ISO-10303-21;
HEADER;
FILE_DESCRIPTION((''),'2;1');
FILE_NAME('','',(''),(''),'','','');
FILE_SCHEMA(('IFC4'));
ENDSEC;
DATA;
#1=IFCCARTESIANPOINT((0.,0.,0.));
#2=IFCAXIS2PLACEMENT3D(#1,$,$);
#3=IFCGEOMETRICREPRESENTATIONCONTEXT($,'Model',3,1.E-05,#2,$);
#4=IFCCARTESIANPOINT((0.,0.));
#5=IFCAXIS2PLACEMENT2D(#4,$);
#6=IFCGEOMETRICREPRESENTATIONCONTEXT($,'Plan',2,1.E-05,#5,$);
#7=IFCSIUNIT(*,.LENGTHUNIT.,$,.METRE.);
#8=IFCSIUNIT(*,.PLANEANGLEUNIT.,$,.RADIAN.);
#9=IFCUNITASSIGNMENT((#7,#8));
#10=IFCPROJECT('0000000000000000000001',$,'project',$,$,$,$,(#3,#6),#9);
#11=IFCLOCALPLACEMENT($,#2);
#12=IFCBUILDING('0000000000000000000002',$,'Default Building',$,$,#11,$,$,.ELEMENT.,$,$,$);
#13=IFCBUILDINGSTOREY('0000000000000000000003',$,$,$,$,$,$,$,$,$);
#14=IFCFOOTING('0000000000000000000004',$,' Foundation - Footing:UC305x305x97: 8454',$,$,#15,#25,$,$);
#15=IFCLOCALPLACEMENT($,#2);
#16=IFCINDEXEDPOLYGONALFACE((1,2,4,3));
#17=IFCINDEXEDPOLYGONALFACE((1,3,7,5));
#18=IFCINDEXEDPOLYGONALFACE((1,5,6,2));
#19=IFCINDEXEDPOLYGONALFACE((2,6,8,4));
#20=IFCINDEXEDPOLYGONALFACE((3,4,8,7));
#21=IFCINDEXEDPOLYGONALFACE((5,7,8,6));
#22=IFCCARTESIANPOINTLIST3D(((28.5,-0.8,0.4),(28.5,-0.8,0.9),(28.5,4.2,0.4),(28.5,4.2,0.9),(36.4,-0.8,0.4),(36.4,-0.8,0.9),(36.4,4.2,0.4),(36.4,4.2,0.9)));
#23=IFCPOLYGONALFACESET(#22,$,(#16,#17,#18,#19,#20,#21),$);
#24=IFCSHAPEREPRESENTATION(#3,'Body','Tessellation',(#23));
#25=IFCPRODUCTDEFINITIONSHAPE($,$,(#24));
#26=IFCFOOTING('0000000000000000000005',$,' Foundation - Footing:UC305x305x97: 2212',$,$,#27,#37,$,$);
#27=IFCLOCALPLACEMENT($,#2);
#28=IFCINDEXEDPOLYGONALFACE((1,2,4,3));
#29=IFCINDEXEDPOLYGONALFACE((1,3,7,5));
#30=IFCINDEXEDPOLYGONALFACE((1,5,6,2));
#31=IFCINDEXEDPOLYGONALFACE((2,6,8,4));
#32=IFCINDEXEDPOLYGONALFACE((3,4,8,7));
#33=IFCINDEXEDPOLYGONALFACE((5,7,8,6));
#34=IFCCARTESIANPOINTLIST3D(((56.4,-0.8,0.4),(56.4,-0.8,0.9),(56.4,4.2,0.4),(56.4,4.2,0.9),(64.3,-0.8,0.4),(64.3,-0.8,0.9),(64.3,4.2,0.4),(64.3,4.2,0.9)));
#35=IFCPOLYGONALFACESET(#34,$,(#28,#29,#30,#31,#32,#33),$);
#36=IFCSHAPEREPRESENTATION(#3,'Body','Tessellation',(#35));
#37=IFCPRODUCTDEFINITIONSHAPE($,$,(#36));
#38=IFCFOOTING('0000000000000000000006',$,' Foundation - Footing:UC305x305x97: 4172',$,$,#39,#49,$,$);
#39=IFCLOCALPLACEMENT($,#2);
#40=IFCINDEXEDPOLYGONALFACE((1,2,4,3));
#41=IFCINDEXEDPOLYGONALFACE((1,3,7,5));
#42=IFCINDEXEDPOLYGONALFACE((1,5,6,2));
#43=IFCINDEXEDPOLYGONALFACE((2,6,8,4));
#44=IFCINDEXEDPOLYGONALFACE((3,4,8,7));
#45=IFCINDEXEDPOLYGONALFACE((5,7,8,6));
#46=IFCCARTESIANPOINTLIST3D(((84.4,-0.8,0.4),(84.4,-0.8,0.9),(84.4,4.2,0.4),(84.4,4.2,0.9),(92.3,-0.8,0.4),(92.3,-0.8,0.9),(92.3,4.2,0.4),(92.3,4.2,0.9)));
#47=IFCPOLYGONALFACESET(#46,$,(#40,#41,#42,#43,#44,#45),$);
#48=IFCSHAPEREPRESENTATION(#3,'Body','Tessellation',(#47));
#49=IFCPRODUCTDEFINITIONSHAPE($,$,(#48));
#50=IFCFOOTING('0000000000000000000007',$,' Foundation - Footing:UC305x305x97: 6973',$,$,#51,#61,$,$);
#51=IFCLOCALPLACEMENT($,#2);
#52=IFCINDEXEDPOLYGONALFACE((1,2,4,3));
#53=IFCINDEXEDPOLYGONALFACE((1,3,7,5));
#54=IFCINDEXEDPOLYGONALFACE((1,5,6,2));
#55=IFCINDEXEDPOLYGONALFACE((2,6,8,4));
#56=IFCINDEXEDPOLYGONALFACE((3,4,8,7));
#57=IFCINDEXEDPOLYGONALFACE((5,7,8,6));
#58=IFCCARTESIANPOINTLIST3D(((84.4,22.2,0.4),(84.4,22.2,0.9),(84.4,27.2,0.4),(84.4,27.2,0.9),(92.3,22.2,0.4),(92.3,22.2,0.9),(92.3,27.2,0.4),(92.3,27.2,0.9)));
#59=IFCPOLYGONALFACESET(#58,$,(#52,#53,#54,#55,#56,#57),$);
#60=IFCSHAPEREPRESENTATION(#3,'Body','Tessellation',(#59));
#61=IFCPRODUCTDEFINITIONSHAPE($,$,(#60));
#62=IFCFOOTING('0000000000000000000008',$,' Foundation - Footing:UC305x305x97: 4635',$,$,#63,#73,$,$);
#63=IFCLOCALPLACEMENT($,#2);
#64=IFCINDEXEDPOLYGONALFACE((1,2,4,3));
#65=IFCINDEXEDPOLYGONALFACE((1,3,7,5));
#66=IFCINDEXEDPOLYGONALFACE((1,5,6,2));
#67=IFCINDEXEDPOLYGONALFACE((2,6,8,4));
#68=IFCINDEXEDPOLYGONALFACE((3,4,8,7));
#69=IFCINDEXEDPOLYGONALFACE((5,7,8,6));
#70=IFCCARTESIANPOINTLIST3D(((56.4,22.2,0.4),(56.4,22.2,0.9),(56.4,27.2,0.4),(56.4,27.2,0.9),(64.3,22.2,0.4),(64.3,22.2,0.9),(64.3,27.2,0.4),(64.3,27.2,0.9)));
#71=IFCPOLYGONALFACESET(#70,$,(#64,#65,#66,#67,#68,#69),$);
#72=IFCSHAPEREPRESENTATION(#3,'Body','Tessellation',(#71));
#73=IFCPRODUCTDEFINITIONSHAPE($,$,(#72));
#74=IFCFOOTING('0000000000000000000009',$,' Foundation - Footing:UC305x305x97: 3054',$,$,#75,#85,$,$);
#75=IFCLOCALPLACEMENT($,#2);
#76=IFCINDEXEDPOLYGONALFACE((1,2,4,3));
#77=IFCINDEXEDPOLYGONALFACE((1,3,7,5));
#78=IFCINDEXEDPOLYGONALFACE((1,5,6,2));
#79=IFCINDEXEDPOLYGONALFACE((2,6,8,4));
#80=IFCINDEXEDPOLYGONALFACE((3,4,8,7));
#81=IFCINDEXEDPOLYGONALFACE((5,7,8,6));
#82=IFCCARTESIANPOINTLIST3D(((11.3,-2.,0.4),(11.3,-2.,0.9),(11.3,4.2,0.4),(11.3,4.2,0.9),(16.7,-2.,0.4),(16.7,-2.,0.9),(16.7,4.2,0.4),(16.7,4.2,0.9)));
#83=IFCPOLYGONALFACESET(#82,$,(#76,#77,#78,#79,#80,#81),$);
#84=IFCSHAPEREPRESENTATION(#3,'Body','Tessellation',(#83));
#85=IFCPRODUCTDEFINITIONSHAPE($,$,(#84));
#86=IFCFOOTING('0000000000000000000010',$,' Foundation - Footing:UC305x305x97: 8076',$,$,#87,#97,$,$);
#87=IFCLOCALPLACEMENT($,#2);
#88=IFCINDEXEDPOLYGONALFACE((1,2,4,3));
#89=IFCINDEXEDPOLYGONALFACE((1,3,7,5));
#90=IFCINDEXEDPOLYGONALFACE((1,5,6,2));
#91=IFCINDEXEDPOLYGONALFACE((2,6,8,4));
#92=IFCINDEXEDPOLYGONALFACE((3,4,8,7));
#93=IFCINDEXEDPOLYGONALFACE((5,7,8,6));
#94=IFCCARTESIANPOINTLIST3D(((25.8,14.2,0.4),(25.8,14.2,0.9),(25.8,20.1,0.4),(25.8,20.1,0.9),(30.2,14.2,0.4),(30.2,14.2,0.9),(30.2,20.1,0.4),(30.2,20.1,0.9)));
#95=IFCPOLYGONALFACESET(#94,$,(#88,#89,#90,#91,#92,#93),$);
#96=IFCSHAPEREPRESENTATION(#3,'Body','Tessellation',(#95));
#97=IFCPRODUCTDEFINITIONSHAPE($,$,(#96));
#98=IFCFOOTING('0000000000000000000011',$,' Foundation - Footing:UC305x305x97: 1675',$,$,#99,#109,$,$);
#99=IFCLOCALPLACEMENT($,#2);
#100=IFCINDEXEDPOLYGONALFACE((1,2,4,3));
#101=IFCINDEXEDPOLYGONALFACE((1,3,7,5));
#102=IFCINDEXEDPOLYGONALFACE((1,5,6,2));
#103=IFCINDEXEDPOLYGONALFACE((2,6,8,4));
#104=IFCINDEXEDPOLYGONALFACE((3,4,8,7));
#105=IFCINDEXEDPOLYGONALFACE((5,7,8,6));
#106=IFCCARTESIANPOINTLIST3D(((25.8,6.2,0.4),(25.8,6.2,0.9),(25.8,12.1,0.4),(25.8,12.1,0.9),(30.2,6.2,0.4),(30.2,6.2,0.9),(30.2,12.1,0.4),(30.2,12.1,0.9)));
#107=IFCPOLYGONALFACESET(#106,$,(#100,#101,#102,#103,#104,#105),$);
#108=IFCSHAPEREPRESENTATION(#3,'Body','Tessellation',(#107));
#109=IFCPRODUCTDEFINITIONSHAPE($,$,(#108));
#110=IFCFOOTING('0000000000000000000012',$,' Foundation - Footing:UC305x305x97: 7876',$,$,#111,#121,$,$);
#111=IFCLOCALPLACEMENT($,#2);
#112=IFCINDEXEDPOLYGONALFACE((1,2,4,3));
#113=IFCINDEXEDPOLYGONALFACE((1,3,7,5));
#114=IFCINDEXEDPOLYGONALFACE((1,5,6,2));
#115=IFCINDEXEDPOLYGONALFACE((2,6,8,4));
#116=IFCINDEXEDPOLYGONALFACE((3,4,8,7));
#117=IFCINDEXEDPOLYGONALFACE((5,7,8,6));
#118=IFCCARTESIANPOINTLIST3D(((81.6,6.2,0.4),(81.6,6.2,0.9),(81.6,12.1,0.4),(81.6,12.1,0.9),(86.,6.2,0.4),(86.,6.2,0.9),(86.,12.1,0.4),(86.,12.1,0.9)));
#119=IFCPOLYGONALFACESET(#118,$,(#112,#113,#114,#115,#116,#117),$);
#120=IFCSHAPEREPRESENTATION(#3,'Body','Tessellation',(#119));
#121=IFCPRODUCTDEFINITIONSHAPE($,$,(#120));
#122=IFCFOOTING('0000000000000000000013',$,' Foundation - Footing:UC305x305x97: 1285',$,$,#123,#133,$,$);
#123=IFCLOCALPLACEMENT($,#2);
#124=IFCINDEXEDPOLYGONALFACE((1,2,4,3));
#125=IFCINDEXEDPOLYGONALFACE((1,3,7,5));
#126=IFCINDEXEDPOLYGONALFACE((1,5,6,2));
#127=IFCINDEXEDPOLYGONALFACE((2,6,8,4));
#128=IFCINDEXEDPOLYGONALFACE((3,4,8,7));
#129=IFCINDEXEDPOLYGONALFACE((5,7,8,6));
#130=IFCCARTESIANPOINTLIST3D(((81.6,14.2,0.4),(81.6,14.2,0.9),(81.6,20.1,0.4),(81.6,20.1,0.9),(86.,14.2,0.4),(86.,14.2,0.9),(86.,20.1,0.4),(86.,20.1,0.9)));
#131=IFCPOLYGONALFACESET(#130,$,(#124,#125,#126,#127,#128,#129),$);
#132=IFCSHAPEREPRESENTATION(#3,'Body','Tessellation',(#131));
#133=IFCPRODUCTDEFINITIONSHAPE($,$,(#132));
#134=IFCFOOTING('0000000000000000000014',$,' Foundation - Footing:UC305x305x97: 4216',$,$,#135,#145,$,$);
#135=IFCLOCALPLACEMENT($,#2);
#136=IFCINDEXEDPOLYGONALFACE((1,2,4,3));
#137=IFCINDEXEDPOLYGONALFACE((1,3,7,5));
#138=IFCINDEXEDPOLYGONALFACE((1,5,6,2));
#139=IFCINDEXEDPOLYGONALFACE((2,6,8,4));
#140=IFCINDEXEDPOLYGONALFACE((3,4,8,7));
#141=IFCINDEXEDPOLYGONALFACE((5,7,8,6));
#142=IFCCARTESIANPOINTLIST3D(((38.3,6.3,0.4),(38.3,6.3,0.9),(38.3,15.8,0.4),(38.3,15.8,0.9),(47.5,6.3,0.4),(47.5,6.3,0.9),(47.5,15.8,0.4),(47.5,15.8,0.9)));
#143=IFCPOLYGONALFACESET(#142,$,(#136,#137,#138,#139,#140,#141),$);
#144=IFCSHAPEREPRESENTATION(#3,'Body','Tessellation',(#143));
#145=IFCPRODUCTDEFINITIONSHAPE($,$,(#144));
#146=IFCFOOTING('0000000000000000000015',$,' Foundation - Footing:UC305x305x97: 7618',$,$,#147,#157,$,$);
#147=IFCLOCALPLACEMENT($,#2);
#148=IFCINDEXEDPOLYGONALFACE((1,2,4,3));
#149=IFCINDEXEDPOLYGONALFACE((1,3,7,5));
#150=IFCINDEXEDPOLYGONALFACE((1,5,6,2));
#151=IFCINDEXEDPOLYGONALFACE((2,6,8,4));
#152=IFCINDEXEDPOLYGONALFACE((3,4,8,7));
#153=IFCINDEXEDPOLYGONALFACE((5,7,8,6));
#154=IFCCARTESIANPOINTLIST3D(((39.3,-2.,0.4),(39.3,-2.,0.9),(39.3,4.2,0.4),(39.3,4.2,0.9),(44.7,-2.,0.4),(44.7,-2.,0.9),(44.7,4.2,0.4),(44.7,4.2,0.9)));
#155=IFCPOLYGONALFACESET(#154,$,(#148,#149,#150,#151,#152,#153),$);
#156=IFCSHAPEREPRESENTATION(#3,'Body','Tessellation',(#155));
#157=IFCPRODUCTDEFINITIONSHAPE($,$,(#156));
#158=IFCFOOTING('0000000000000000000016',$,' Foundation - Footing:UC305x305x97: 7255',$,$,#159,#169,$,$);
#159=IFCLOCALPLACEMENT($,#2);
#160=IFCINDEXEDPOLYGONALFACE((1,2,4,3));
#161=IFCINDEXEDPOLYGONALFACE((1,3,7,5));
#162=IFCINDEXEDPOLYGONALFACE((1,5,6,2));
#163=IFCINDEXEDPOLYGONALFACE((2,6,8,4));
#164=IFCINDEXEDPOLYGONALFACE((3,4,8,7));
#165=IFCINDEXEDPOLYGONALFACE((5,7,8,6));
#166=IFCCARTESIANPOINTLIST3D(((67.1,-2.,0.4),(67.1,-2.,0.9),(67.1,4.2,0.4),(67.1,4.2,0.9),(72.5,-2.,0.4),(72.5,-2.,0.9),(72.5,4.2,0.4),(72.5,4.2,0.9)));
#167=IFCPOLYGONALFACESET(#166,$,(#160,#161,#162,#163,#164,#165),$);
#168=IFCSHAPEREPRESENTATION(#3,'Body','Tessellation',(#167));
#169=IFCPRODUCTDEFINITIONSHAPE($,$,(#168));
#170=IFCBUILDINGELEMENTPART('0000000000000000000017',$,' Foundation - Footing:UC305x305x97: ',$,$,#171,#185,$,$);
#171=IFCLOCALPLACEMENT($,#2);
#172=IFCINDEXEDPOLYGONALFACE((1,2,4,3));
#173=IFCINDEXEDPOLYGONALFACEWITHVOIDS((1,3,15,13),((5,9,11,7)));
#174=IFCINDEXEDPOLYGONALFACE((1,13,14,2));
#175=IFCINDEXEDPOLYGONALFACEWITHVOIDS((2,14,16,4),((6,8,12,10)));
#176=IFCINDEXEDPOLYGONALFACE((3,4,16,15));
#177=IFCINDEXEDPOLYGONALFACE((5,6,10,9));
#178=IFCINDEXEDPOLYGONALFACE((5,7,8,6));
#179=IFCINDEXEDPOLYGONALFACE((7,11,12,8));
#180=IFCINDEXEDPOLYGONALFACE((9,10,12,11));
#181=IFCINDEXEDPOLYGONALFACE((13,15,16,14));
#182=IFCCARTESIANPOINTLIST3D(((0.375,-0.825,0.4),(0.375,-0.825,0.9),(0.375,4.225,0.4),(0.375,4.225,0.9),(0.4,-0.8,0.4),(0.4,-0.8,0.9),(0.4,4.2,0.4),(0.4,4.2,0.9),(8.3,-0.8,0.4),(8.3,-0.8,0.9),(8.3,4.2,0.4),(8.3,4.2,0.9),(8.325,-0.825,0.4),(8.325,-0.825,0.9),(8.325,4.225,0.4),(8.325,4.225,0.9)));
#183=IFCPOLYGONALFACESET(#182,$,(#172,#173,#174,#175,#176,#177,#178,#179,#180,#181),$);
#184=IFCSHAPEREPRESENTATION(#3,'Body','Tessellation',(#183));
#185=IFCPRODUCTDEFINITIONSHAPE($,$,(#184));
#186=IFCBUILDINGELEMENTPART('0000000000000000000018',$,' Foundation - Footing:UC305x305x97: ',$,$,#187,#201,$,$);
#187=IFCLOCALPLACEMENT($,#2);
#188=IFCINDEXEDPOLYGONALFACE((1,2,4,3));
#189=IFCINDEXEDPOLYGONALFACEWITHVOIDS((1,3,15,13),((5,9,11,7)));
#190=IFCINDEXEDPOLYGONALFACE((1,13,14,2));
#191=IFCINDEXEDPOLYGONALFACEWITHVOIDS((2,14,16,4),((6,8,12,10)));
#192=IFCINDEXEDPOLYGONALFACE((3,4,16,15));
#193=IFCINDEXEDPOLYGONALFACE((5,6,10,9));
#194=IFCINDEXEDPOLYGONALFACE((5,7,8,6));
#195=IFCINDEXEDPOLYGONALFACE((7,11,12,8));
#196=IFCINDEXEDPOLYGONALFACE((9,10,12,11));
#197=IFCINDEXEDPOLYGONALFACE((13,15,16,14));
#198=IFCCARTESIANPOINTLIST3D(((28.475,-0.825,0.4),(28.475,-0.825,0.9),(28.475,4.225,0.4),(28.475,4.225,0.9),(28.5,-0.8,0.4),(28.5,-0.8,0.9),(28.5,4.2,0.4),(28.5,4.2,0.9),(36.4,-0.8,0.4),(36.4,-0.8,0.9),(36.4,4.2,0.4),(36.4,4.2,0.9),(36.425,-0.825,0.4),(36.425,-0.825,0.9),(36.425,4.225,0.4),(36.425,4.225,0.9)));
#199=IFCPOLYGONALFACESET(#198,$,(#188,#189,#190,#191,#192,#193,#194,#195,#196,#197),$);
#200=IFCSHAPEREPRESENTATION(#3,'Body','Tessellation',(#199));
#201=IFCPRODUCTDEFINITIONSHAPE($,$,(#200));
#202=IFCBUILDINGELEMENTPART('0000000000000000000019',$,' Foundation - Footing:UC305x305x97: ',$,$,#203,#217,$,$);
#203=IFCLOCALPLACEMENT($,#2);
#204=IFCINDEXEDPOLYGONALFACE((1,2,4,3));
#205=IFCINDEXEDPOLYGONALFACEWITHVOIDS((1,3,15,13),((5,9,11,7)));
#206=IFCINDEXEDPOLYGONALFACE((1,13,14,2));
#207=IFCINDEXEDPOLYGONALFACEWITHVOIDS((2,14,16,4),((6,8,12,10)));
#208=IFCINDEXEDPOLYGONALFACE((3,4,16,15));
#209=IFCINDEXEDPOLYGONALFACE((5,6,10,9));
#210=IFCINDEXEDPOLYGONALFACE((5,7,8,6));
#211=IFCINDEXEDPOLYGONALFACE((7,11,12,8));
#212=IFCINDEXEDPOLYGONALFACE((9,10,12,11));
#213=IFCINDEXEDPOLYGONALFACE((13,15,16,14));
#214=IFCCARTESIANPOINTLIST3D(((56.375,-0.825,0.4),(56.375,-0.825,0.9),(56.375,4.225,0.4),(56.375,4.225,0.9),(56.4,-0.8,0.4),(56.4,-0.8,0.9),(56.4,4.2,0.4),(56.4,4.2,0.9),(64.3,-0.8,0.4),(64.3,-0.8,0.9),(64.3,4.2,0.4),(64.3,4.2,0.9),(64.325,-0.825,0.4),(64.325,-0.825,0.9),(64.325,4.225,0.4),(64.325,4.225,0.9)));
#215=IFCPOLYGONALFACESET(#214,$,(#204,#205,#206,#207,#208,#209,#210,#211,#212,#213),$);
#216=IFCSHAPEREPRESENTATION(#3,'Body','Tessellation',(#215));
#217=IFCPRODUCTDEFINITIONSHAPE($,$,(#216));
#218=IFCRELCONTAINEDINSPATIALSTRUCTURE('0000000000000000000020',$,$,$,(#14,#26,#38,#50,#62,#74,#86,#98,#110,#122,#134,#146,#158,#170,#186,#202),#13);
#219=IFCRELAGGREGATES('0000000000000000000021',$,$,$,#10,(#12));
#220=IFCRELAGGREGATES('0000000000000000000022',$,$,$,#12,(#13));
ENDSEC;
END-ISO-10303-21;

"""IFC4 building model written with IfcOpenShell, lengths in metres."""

from ifc_helpers import new_model, si_unit, origin, origin_2d, place, context, project, spatial, polyline, outline, extrude, element, save


model = new_model("IFC4")

# Units and contexts
model_context = context("Model", 3, precision=1e-05, world=origin())
plan_context = context("Plan", 2, precision=1e-05, world=origin_2d())
ifc_project = project(units=[si_unit("LENGTHUNIT", "METRE"), si_unit("PLANEANGLEUNIT", "RADIAN")], contexts=[model_context, plan_context])

# Building, storey
building_placement = place(None, origin())
building = spatial("IfcBuilding", under=ifc_project, at=building_placement, Name="Default Building", CompositionType="ELEMENT")
storey = spatial("IfcBuildingStorey", under=building)

# Footings
element("IfcFooting", 1, inside=storey, Name=" Foundation - Footing:UC305x305x97: 8454", context=model_context, shape_type="SweptSolid", body=[
    extrude(outline(polyline([(36.4, 4.2, 0.4), (28.5, 4.2, 0.4), (28.5, -0.8, 0.4), (36.4, -0.8, 0.4), (36.4, 4.2, 0.4)])), None, (0.0, 0.0, 1.0), 0.5),
])
element("IfcFooting", 2, inside=storey, Name=" Foundation - Footing:UC305x305x97: 2212", context=model_context, shape_type="SweptSolid", body=[
    extrude(outline(polyline([(64.3, 4.2, 0.4), (56.4, 4.2, 0.4), (56.4, -0.8, 0.4), (64.3, -0.8, 0.4), (64.3, 4.2, 0.4)])), None, (0.0, 0.0, 1.0), 0.5),
])
element("IfcFooting", 3, inside=storey, Name=" Foundation - Footing:UC305x305x97: 4172", context=model_context, shape_type="SweptSolid", body=[
    extrude(outline(polyline([(92.3, 4.2, 0.4), (84.4, 4.2, 0.4), (84.4, -0.8, 0.4), (92.3, -0.8, 0.4), (92.3, 4.2, 0.4)])), None, (0.0, 0.0, 1.0), 0.5),
])
element("IfcFooting", 4, inside=storey, Name=" Foundation - Footing:UC305x305x97: 6973", context=model_context, shape_type="SweptSolid", body=[
    extrude(outline(polyline([(92.3, 27.2, 0.4), (84.4, 27.2, 0.4), (84.4, 22.2, 0.4), (92.3, 22.2, 0.4), (92.3, 27.2, 0.4)])), None, (0.0, 0.0, 1.0), 0.5),
])
element("IfcFooting", 5, inside=storey, Name=" Foundation - Footing:UC305x305x97: 4635", context=model_context, shape_type="SweptSolid", body=[
    extrude(outline(polyline([(64.3, 27.2, 0.4), (56.4, 27.2, 0.4), (56.4, 22.2, 0.4), (64.3, 22.2, 0.4), (64.3, 27.2, 0.4)])), None, (0.0, 0.0, 1.0), 0.5),
])
element("IfcFooting", 6, inside=storey, Name=" Foundation - Footing:UC305x305x97: 3054", context=model_context, shape_type="SweptSolid", body=[
    extrude(outline(polyline([(16.7, -2.0, 0.4), (16.7, 4.2, 0.4), (11.3, 4.2, 0.4), (11.3, -2.0, 0.4), (16.7, -2.0, 0.4)])), None, (0.0, 0.0, 1.0), 0.5),
])
element("IfcFooting", 7, inside=storey, Name=" Foundation - Footing:UC305x305x97: 8076", context=model_context, shape_type="SweptSolid", body=[
    extrude(outline(polyline([(30.2, 20.1, 0.4), (25.8, 20.1, 0.4), (25.8, 14.2, 0.4), (30.2, 14.2, 0.4), (30.2, 20.1, 0.4)])), None, (0.0, 0.0, 1.0), 0.5),
])
element("IfcFooting", 8, inside=storey, Name=" Foundation - Footing:UC305x305x97: 1675", context=model_context, shape_type="SweptSolid", body=[
    extrude(outline(polyline([(30.2, 12.1, 0.4), (25.8, 12.1, 0.4), (25.8, 6.2, 0.4), (30.2, 6.2, 0.4), (30.2, 12.1, 0.4)])), None, (0.0, 0.0, 1.0), 0.5),
])
element("IfcFooting", 9, inside=storey, Name=" Foundation - Footing:UC305x305x97: 7876", context=model_context, shape_type="SweptSolid", body=[
    extrude(outline(polyline([(86.0, 12.1, 0.4), (81.6, 12.1, 0.4), (81.6, 6.2, 0.4), (86.0, 6.2, 0.4), (86.0, 12.1, 0.4)])), None, (0.0, 0.0, 1.0), 0.5),
])
element("IfcFooting", 10, inside=storey, Name=" Foundation - Footing:UC305x305x97: 1285", context=model_context, shape_type="SweptSolid", body=[
    extrude(outline(polyline([(86.0, 20.1, 0.4), (81.6, 20.1, 0.4), (81.6, 14.2, 0.4), (86.0, 14.2, 0.4), (86.0, 20.1, 0.4)])), None, (0.0, 0.0, 1.0), 0.5),
])
element("IfcFooting", 11, inside=storey, Name=" Foundation - Footing:UC305x305x97: 4216", context=model_context, shape_type="SweptSolid", body=[
    extrude(outline(polyline([(38.3, 15.8, 0.4), (47.5, 15.8, 0.4), (47.5, 6.3, 0.4), (38.3, 6.3, 0.4), (38.3, 15.8, 0.4)])), None, (0.0, 0.0, 1.0), 0.5),
])
element("IfcFooting", 12, inside=storey, Name=" Foundation - Footing:UC305x305x97: 7618", context=model_context, shape_type="SweptSolid", body=[
    extrude(outline(polyline([(44.7, -2.0, 0.4), (44.7, 4.2, 0.4), (39.3, 4.2, 0.4), (39.3, -2.0, 0.4), (44.7, -2.0, 0.4)])), None, (0.0, 0.0, 1.0), 0.5),
])
element("IfcFooting", 13, inside=storey, Name=" Foundation - Footing:UC305x305x97: 7255", context=model_context, shape_type="SweptSolid", body=[
    extrude(outline(polyline([(72.5, -2.0, 0.4), (72.5, 4.2, 0.4), (67.1, 4.2, 0.4), (67.1, -2.0, 0.4), (72.5, -2.0, 0.4)])), None, (0.0, 0.0, 1.0), 0.5),
])

# Building element parts, openings
building_element_part_1 = element("IfcBuildingElementPart", 14, inside=storey, Name=" Foundation - Footing:UC305x305x97: ", context=model_context, shape_type="SweptSolid", body=[
    extrude(outline(polyline([(8.325, 4.225, 0.4), (0.375, 4.225, 0.4), (0.375, -0.825, 0.4), (8.325, -0.825, 0.4), (8.325, 4.225, 0.4)])), None, (0.0, 0.0, 1.0), 0.5),
])
element("IfcOpeningElement", 15, inside=storey, cuts=building_element_part_1, context=model_context, shape_type="SweptSolid", body=[
    extrude(outline(polyline([(8.3, 4.2, 0.4), (0.4, 4.2, 0.4), (0.4, -0.8, 0.4), (8.3, -0.8, 0.4), (8.3, 4.2, 0.4)])), None, (0.0, 0.0, 1.0), 0.5),
])
building_element_part_2 = element("IfcBuildingElementPart", 16, inside=storey, Name=" Foundation - Footing:UC305x305x97: ", context=model_context, shape_type="SweptSolid", body=[
    extrude(outline(polyline([(36.425, 4.225, 0.4), (28.475, 4.225, 0.4), (28.475, -0.825, 0.4), (36.425, -0.825, 0.4), (36.425, 4.225, 0.4)])), None, (0.0, 0.0, 1.0), 0.5),
])
element("IfcOpeningElement", 17, inside=storey, cuts=building_element_part_2, context=model_context, shape_type="SweptSolid", body=[
    extrude(outline(polyline([(36.4, 4.2, 0.4), (28.5, 4.2, 0.4), (28.5, -0.8, 0.4), (36.4, -0.8, 0.4), (36.4, 4.2, 0.4)])), None, (0.0, 0.0, 1.0), 0.5),
])
building_element_part_3 = element("IfcBuildingElementPart", 18, inside=storey, Name=" Foundation - Footing:UC305x305x97: ", context=model_context, shape_type="SweptSolid", body=[
    extrude(outline(polyline([(64.325, 4.225, 0.4), (56.375, 4.225, 0.4), (56.375, -0.825, 0.4), (64.325, -0.825, 0.4), (64.325, 4.225, 0.4)])), None, (0.0, 0.0, 1.0), 0.5),
])
element("IfcOpeningElement", 19, inside=storey, cuts=building_element_part_3, context=model_context, shape_type="SweptSolid", body=[
    extrude(outline(polyline([(64.3, 4.2, 0.4), (56.4, 4.2, 0.4), (56.4, -0.8, 0.4), (64.3, -0.8, 0.4), (64.3, 4.2, 0.4)])), None, (0.0, 0.0, 1.0), 0.5),
])

save(model, "model.ifc")
